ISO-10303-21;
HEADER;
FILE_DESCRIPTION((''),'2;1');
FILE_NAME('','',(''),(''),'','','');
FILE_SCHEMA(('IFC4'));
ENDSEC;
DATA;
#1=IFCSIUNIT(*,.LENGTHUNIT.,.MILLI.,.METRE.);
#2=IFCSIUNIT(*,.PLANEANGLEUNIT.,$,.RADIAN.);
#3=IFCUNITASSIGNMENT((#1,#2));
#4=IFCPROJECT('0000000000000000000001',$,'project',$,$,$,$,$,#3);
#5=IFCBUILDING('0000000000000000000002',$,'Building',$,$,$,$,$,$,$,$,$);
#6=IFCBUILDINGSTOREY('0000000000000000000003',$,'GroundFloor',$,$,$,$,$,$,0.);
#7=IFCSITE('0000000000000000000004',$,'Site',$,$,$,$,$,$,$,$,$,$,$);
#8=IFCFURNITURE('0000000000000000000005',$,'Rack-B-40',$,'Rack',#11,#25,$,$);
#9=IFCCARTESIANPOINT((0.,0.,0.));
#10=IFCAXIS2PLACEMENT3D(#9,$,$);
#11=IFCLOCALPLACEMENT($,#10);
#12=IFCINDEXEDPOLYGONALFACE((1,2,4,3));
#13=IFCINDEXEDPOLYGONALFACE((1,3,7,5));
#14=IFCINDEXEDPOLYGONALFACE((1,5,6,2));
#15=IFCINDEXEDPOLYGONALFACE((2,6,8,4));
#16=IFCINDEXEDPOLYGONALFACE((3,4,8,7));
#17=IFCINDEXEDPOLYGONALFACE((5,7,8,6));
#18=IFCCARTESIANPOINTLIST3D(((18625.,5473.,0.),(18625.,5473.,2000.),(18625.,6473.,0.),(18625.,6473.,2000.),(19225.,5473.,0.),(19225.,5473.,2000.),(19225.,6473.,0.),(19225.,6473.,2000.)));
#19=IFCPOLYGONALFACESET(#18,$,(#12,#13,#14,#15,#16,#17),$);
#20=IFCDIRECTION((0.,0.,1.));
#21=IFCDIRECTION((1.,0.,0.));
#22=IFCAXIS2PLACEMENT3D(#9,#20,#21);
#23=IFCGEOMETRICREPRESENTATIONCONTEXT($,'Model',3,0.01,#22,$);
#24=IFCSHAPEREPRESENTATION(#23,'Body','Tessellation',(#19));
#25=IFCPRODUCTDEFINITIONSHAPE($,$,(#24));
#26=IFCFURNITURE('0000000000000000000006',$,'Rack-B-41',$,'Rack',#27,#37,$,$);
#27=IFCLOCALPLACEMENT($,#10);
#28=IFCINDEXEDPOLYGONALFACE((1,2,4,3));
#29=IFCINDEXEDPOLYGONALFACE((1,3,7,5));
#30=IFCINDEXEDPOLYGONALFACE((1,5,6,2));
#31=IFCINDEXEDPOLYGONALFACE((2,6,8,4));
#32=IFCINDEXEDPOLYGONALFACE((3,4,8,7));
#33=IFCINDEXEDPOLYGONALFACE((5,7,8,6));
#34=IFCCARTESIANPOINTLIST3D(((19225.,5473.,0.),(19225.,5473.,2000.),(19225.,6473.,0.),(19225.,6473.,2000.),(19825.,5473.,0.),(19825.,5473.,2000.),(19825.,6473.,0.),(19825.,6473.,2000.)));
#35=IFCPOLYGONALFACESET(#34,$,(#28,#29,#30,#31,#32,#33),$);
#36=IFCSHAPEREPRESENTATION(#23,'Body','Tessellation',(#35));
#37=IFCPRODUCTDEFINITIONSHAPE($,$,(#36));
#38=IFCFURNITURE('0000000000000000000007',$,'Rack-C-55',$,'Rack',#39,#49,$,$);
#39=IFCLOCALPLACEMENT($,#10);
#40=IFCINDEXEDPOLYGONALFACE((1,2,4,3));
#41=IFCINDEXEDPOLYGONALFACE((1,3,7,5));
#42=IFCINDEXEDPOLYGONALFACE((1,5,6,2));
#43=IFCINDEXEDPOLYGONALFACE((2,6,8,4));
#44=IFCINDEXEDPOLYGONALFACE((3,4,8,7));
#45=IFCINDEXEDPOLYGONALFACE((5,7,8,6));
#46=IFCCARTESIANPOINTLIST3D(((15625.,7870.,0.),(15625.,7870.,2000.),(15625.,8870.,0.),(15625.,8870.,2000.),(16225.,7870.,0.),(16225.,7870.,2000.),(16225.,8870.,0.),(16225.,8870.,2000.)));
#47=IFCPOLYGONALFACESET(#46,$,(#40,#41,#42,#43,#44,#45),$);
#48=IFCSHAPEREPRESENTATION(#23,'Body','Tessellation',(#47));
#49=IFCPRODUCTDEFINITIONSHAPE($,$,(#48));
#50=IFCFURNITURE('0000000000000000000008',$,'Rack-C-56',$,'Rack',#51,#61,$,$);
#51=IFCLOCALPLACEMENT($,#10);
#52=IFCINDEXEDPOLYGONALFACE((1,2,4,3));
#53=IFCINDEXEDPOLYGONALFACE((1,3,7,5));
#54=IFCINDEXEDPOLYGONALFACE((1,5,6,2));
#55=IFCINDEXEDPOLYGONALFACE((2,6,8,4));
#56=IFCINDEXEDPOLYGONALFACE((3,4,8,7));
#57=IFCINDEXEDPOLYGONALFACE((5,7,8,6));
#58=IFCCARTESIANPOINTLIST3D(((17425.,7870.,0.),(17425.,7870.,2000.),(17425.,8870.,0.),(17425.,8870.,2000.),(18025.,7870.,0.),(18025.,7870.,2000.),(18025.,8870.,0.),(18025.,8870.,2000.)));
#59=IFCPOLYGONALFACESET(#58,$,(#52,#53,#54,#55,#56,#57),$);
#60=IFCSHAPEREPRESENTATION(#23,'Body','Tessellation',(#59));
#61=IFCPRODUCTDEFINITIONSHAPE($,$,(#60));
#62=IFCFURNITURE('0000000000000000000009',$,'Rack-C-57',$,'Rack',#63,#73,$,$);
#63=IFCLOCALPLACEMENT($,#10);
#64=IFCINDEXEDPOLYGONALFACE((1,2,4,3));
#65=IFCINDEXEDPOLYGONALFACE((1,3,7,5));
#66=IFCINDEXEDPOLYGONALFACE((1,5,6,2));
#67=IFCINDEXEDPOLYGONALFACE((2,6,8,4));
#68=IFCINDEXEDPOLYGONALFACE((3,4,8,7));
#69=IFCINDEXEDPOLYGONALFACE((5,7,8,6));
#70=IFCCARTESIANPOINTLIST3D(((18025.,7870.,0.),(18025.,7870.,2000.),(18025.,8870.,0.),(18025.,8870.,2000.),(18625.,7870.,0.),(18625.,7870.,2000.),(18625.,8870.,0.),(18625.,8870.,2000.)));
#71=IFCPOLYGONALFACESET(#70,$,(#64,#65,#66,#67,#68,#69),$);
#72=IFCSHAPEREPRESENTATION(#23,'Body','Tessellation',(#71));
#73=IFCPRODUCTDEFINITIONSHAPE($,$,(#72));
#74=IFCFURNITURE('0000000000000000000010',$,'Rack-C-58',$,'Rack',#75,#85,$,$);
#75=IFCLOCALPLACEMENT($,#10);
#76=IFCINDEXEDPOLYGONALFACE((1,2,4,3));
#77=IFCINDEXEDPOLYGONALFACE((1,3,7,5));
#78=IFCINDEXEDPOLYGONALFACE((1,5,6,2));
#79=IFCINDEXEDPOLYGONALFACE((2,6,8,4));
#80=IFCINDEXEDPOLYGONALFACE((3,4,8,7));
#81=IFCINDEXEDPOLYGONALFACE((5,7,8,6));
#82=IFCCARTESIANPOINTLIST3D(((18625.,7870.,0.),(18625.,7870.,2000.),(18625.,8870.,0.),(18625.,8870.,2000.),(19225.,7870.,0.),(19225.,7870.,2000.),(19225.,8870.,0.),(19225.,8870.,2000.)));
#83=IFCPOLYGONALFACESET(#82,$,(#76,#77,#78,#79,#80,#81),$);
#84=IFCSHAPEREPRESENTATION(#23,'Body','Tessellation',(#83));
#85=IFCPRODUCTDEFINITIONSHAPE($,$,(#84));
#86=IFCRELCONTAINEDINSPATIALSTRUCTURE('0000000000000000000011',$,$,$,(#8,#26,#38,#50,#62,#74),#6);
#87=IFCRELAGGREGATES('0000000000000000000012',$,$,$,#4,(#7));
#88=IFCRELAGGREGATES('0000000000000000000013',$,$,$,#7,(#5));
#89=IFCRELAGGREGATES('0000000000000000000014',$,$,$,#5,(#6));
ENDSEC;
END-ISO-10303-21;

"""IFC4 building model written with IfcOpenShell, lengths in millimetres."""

from ifc_helpers import new_model, si_unit, frame, origin, origin_with_axes, origin_2d, place, context, project, spatial, rectangle, extrude, element, save


model = new_model("IFC4")

# Units and contexts
model_context = context("Model", 3, precision=0.01, world=origin_with_axes())
ifc_project = project(units=[si_unit("LENGTHUNIT", "METRE", prefix="MILLI"), si_unit("PLANEANGLEUNIT", "RADIAN")])

# Site, building, storey
site = spatial("IfcSite", under=ifc_project, Name="Site")
building = spatial("IfcBuilding", under=site, Name="Building")
storey = spatial("IfcBuildingStorey", under=building, Name="GroundFloor", Elevation=0.0)

# Furniture
for number, where, z_axis, x_axis, name in (
    (1, (18925.0, 5973.0, 0.0), (0.0, 0.0, 1.0), (1.0, 0.0, 0.0), "Rack-B-40"),
    (2, (19525.0, 5973.0, 0.0), (0.0, 0.0, 1.0), (1.0, 0.0, 0.0), "Rack-B-41"),
    (3, (15925.0, 8370.0, 0.0), (0.0, 0.0, 1.0), (1.0, 0.0, 0.0), "Rack-C-55"),
    (4, (17725.0, 8370.0, 0.0), (0.0, 0.0, 1.0), (1.0, 0.0, 0.0), "Rack-C-56"),
    (5, (18325.0, 8370.0, 0.0), (0.0, 0.0, 1.0), (1.0, 0.0, 0.0), "Rack-C-57"),
    (6, (18925.0, 8370.0, 0.0), (0.0, 0.0, 1.0), (1.0, 0.0, 0.0), "Rack-C-58"),
):
    element("IfcFurniture", number, at=place(None, frame(where, z_axis=z_axis, x_axis=x_axis)), inside=storey, Name=name, ObjectType="Rack", context=model_context, shape_type="SweptSolid", body=[
        extrude(rectangle(XDim=600.0, YDim=1000.0, at=origin_2d()), origin(), (0.0, 0.0, 1.0), 2000.0),
    ])

save(model, "model.ifc")
